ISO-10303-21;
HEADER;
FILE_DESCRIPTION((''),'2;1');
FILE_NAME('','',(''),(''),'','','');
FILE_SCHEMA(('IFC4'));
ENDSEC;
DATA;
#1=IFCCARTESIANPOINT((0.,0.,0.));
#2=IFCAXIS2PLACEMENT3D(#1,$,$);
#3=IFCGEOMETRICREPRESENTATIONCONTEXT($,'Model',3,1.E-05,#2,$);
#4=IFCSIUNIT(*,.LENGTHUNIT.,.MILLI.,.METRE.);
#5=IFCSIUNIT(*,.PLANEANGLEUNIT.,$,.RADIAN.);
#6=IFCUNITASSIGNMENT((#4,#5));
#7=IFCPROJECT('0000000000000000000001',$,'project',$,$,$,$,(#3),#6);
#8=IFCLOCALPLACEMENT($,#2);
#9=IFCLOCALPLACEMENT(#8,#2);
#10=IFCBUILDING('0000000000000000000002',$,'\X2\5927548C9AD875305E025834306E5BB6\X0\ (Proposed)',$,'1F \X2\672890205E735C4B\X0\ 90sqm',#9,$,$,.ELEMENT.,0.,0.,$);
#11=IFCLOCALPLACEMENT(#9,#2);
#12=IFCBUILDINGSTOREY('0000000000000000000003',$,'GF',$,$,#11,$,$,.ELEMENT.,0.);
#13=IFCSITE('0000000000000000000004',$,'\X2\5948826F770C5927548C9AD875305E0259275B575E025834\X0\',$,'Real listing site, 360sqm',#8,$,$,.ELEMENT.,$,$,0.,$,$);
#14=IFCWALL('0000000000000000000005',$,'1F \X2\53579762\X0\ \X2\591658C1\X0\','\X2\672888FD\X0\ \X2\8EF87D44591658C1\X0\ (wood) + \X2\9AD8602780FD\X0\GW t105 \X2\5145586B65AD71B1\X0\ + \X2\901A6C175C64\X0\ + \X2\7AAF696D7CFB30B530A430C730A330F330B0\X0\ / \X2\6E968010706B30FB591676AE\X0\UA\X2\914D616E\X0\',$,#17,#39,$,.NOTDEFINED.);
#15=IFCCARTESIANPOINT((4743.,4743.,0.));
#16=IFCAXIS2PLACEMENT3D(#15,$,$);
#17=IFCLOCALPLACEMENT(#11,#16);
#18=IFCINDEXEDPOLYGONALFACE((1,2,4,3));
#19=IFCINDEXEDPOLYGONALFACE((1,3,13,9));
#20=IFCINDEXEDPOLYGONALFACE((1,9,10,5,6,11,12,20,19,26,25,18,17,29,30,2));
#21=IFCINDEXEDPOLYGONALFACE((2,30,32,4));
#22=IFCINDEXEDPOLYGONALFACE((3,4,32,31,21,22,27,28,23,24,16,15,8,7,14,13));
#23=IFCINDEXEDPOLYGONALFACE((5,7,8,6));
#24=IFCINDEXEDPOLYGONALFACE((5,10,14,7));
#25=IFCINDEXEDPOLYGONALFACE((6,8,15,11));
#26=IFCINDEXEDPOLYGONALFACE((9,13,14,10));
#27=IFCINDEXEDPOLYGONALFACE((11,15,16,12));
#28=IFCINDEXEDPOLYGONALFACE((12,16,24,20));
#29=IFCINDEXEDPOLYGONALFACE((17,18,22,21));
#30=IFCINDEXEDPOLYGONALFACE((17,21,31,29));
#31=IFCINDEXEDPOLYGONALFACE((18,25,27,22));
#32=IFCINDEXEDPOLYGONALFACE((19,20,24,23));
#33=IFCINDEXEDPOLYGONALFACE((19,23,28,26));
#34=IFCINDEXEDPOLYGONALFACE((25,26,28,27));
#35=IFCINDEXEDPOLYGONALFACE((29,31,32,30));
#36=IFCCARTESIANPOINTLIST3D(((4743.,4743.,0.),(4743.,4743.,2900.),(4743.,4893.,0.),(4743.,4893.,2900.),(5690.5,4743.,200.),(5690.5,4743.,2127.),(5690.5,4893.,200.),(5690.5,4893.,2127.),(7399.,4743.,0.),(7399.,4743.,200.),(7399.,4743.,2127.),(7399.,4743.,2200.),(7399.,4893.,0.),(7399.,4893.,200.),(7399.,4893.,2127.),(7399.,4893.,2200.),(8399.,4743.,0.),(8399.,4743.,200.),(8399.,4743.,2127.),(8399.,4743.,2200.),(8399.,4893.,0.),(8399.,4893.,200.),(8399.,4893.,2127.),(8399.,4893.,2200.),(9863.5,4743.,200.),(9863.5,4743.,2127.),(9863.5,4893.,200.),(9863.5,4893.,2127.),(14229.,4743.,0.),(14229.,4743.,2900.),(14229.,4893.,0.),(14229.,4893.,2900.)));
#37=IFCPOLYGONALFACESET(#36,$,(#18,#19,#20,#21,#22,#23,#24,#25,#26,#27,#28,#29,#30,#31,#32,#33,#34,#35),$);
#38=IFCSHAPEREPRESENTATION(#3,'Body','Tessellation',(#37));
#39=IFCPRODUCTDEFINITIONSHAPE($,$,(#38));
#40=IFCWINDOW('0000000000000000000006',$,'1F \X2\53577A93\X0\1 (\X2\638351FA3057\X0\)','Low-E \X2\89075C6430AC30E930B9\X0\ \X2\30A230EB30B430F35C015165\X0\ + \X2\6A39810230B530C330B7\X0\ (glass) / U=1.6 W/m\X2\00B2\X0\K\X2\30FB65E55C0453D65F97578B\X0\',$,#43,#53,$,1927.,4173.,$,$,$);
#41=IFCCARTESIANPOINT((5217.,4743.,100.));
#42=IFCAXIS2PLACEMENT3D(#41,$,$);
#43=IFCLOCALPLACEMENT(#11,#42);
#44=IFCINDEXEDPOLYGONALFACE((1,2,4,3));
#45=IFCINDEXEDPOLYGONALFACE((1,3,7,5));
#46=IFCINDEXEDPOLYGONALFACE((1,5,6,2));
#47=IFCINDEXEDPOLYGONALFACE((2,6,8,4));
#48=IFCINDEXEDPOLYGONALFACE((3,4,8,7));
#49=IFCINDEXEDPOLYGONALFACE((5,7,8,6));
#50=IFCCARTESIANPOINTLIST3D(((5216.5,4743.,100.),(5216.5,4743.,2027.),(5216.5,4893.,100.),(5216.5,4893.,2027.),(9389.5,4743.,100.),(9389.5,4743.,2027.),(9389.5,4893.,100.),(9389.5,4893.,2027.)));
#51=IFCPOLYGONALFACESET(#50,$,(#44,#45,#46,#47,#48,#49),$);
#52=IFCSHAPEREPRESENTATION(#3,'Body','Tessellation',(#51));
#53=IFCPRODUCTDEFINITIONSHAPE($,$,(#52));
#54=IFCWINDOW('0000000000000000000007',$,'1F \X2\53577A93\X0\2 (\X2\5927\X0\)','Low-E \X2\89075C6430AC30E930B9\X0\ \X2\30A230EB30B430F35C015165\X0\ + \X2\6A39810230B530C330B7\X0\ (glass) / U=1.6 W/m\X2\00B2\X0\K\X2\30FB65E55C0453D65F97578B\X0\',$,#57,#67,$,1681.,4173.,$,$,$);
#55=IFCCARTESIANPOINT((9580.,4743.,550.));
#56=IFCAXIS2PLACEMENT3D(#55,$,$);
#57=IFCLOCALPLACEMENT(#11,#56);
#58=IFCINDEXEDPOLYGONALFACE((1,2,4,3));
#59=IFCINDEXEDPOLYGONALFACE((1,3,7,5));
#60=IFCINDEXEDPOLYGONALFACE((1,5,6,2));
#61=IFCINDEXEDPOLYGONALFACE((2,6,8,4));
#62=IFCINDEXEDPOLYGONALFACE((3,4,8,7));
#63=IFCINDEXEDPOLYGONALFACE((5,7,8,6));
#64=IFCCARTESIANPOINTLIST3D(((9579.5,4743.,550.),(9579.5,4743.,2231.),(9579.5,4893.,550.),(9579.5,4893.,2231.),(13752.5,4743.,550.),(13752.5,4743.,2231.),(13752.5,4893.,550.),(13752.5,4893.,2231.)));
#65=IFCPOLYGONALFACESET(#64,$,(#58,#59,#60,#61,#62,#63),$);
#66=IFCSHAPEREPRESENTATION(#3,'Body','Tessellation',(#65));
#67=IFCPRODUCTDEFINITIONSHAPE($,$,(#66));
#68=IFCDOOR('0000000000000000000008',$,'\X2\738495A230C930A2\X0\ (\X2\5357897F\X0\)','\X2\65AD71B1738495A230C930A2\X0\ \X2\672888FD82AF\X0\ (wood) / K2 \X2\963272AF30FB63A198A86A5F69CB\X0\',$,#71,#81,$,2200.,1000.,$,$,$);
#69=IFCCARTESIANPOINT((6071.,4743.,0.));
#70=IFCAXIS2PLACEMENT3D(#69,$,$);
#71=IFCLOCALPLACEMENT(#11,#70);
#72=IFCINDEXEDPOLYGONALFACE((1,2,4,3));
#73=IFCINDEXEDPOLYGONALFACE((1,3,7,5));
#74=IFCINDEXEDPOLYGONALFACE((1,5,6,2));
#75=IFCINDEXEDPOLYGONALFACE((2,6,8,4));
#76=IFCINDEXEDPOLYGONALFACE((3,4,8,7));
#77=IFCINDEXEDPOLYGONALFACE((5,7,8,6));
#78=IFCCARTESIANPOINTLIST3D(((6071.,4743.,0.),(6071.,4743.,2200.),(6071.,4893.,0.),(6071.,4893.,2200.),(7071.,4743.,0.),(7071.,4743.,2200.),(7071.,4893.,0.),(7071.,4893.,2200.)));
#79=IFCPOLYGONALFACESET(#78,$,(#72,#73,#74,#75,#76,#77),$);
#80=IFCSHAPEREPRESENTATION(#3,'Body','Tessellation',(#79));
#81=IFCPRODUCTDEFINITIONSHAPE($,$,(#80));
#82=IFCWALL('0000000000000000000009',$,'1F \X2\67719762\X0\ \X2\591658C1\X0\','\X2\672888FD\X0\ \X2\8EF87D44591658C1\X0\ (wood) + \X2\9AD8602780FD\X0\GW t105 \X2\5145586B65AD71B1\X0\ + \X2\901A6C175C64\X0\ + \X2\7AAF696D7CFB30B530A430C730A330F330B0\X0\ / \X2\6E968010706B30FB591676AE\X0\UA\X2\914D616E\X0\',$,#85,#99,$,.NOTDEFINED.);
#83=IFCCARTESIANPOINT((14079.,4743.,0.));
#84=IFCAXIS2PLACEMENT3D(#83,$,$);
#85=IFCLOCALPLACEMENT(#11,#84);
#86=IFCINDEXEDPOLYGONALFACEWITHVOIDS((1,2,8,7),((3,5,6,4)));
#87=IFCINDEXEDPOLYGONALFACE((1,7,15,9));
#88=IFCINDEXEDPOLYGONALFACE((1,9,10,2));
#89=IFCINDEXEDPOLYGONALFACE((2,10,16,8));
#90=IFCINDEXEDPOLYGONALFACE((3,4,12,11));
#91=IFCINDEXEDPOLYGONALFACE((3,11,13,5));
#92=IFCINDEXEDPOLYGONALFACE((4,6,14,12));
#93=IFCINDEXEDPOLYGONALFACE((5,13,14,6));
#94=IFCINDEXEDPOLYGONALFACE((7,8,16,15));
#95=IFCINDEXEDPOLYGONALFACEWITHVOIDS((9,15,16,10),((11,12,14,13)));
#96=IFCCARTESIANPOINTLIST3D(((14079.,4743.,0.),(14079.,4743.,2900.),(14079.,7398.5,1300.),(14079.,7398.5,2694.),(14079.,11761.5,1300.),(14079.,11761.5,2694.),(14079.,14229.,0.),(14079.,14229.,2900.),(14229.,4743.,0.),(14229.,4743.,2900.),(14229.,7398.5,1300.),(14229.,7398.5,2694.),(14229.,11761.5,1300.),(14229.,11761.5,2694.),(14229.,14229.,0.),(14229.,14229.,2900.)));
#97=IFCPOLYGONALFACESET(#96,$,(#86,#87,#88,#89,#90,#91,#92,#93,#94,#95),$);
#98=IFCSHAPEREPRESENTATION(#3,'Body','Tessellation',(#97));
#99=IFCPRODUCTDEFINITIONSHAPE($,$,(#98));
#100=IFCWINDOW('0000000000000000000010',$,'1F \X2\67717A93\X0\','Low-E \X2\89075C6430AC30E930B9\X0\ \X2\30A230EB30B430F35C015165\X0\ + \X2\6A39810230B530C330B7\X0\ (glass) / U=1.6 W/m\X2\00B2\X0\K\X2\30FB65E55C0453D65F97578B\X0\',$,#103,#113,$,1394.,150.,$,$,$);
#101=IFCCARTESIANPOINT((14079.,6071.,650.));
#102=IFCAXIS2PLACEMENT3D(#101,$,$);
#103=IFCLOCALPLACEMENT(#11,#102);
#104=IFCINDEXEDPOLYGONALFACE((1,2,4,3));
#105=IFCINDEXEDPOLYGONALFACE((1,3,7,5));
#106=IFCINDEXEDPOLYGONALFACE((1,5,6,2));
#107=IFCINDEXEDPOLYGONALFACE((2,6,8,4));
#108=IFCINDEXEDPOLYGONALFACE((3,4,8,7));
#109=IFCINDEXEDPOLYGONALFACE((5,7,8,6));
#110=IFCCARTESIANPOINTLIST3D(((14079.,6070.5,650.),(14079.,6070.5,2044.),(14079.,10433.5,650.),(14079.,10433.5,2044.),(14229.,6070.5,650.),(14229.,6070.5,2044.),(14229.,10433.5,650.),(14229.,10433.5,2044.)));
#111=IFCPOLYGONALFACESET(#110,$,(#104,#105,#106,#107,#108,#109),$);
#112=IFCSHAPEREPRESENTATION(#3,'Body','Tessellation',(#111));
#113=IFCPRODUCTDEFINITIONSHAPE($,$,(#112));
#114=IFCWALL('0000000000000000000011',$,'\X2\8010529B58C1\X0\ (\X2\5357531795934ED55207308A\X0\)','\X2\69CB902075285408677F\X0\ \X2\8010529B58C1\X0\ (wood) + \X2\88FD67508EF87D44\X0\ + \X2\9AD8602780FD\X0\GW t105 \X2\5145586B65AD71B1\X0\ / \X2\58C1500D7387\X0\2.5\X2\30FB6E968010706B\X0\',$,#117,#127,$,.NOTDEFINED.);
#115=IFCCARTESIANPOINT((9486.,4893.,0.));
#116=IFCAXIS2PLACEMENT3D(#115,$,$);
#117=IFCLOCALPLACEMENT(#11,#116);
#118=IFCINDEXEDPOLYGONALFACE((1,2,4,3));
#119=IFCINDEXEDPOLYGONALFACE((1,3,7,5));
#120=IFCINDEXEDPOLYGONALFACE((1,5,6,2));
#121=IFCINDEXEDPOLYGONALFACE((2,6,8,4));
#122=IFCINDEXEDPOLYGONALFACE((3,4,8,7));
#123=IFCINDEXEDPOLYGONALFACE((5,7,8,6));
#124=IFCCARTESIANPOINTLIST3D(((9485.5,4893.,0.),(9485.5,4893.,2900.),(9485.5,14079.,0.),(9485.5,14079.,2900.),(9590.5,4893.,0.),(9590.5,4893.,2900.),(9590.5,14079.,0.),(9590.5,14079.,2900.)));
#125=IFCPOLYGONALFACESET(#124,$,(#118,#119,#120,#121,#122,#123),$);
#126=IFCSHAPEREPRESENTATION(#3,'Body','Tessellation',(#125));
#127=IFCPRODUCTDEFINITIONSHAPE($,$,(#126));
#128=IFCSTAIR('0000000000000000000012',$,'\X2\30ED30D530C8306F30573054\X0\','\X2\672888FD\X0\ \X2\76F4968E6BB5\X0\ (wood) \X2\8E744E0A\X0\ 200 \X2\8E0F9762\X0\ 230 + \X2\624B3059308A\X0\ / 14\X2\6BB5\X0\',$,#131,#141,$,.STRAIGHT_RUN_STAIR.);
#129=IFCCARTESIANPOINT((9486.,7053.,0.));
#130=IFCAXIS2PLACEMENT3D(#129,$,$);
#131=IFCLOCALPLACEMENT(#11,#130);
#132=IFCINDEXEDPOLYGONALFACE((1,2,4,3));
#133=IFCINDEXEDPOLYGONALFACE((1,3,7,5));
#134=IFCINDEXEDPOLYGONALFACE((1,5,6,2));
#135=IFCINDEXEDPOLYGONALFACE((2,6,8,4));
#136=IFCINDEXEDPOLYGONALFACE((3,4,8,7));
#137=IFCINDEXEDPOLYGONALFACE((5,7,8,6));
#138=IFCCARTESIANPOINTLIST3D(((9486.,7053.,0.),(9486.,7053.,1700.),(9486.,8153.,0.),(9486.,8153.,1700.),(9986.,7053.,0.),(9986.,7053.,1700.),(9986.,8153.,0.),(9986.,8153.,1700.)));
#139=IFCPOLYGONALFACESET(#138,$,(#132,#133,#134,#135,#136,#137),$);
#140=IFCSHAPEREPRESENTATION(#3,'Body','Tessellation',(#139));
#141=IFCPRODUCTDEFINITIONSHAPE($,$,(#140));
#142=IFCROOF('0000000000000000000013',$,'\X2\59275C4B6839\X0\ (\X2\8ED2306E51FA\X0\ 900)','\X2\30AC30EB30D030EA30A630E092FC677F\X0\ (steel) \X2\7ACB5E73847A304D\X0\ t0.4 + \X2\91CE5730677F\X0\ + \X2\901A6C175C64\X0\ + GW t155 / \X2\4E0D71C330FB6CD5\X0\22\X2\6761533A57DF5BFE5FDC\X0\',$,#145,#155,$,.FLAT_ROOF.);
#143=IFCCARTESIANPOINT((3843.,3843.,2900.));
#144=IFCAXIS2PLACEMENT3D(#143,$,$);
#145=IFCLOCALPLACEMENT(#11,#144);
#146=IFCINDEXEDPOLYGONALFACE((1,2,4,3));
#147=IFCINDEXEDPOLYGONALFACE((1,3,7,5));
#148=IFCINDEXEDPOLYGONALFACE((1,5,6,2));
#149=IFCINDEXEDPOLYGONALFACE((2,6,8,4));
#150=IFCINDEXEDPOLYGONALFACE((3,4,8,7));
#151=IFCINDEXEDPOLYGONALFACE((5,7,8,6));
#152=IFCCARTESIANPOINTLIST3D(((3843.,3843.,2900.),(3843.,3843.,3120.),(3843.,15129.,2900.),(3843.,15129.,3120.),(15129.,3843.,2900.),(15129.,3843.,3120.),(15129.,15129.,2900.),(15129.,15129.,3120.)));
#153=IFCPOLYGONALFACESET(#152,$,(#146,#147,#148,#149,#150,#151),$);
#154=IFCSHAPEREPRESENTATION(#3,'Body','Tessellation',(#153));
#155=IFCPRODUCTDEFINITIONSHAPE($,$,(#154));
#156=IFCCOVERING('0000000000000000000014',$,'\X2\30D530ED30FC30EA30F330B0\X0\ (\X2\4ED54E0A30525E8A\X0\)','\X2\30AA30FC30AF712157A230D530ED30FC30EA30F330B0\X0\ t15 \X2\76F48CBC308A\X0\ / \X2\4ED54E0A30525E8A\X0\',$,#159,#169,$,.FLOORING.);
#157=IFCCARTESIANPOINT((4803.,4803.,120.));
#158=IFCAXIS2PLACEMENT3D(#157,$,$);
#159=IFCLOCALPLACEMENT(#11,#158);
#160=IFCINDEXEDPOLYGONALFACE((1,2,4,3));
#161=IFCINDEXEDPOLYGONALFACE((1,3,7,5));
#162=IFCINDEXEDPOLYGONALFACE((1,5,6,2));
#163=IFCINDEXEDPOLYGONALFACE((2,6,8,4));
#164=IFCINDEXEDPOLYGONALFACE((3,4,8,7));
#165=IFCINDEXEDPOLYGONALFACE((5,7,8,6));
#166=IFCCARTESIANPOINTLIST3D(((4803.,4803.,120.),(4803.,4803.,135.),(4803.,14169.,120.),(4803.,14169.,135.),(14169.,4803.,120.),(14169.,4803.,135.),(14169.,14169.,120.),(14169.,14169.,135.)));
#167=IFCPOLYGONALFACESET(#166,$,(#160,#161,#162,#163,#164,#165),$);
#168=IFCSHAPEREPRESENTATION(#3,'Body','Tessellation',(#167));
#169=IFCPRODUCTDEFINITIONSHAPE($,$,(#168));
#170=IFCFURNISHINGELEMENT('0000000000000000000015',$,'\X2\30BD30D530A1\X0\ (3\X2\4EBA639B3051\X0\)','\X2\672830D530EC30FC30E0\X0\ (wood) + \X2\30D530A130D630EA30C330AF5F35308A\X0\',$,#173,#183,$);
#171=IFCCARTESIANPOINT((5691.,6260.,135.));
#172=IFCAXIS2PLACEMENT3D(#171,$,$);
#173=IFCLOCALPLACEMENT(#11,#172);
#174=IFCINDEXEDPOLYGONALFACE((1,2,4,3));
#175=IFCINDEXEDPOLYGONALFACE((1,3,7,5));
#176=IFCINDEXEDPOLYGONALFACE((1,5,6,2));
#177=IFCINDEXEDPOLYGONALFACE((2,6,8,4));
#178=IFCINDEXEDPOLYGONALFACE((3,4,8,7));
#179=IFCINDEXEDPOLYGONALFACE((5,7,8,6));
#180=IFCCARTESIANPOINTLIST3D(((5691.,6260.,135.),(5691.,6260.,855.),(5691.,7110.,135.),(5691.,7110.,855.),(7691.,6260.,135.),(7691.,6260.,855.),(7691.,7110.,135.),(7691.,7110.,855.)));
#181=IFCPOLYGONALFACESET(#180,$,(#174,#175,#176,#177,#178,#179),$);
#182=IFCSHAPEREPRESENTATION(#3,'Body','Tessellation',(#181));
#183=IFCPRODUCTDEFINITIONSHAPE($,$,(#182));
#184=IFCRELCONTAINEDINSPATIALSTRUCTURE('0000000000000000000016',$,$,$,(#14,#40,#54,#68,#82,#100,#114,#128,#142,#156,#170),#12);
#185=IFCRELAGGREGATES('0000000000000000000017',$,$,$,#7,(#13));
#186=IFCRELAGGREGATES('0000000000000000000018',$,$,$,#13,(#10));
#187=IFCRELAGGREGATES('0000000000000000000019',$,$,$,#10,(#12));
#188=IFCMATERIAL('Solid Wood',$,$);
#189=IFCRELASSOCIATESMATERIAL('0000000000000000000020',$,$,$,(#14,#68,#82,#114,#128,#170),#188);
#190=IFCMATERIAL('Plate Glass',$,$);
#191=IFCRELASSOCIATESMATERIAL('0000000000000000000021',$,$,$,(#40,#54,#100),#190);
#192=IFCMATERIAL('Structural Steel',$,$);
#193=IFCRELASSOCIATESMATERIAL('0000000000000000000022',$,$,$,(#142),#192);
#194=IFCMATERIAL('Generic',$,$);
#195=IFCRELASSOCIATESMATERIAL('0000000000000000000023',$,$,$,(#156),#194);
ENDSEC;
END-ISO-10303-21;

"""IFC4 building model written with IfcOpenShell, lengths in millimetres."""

from ifc_helpers import new_model, si_unit, frame, frame_2d, origin, place, context, project, spatial, rectangle, extrude, material, element, fill, save


model = new_model("IFC4")

# Units and contexts
model_context = context("Model", 3, precision=1e-05, world=origin())
ifc_project = project(units=[si_unit("LENGTHUNIT", "METRE", prefix="MILLI"), si_unit("PLANEANGLEUNIT", "RADIAN")], contexts=[model_context])

# Site, building, storey
site_placement = place(None, origin())
site = spatial("IfcSite", under=ifc_project, at=site_placement, Name="奈良県大和高田市大字市場", ObjectType="Real listing site, 360sqm", CompositionType="ELEMENT", RefElevation=0.0)
building_placement = place(site_placement, origin())
building = spatial("IfcBuilding", under=site, at=building_placement, Name="大和高田市場の家 (Proposed)", ObjectType="1F 木造平屋 90sqm", CompositionType="ELEMENT", ElevationOfRefHeight=0.0, ElevationOfTerrain=0.0)
storey_placement = place(building_placement, origin())
storey = spatial("IfcBuildingStorey", under=building, at=storey_placement, Name="GF", CompositionType="ELEMENT", Elevation=0.0)

# Shared definitions
ifc_material_1 = material(Name="Solid Wood")

# Wall, openings, windows, door
wall_1_placement = place(storey_placement, frame((4743.0, 4743.0, 0.0)))
wall_1 = element("IfcWall", 1, at=wall_1_placement, inside=storey, material=ifc_material_1, Name="1F 南面 外壁", Description="木製 軸組外壁 (wood) + 高性能GW t105 充填断熱 + 通気層 + 窯業系サイディング / 準耐火・外皮UA配慮", PredefinedType="NOTDEFINED", context=model_context, shape_type="SweptSolid", body=[
    extrude(rectangle(XDim=9486.0, YDim=150.0, at=frame_2d((4743.0, 75.0))), frame((4743.0, 4743.0, 0.0)), (0.0, 0.0, 1.0), 2900.0),
])
opening_1_placement = place(storey_placement, frame((5217.0, 4743.0, 100.0)))
opening_1 = element("IfcOpeningElement", 2, at=opening_1_placement, cuts=wall_1, PredefinedType="NOTDEFINED", context=model_context, shape_type="SweptSolid", body=[
    extrude(rectangle(XDim=4173.0, YDim=150.0, at=frame_2d((2086.0, 75.0))), frame((5217.0, 4743.0, 100.0)), (0.0, 0.0, 1.0), 1927.0),
])
opening_2_placement = place(storey_placement, frame((9580.0, 4743.0, 550.0)))
opening_2 = element("IfcOpeningElement", 3, at=opening_2_placement, cuts=wall_1, PredefinedType="NOTDEFINED", context=model_context, shape_type="SweptSolid", body=[
    extrude(rectangle(XDim=4173.0, YDim=150.0, at=frame_2d((2086.0, 75.0))), frame((9580.0, 4743.0, 550.0)), (0.0, 0.0, 1.0), 1681.0),
])
opening_3_placement = place(storey_placement, frame((6071.0, 4743.0, 0.0)))
opening_3 = element("IfcOpeningElement", 4, at=opening_3_placement, cuts=wall_1, PredefinedType="NOTDEFINED", context=model_context, shape_type="SweptSolid", body=[
    extrude(rectangle(XDim=1000.0, YDim=150.0, at=frame_2d((500.0, 75.0))), frame((6071.0, 4743.0, 0.0)), (0.0, 0.0, 1.0), 2200.0),
])
ifc_material_2 = material(Name="Plate Glass")
window_1_placement = place(storey_placement, frame((5217.0, 4743.0, 100.0)))
window_1 = element("IfcWindow", 5, at=window_1_placement, inside=storey, material=ifc_material_2, Name="1F 南窓1 (掃出し)", Description="Low-E 複層ガラス アルゴン封入 + 樹脂サッシ (glass) / U=1.6 W/m²K・日射取得型", OverallHeight=1927.0, OverallWidth=4173.0, context=model_context, shape_type="SweptSolid", body=[
    extrude(rectangle(XDim=4173.0, YDim=150.0, at=frame_2d((2086.0, 75.0))), frame((5217.0, 4743.0, 100.0)), (0.0, 0.0, 1.0), 1927.0),
])
fill(opening_1, window_1)
window_2_placement = place(storey_placement, frame((9580.0, 4743.0, 550.0)))
window_2 = element("IfcWindow", 6, at=window_2_placement, inside=storey, material=ifc_material_2, Name="1F 南窓2 (大)", Description="Low-E 複層ガラス アルゴン封入 + 樹脂サッシ (glass) / U=1.6 W/m²K・日射取得型", OverallHeight=1681.0, OverallWidth=4173.0, context=model_context, shape_type="SweptSolid", body=[
    extrude(rectangle(XDim=4173.0, YDim=150.0, at=frame_2d((2086.0, 75.0))), frame((9580.0, 4743.0, 550.0)), (0.0, 0.0, 1.0), 1681.0),
])
fill(opening_2, window_2)
door_placement = place(storey_placement, frame((6071.0, 4743.0, 0.0)))
door = element("IfcDoor", 7, at=door_placement, inside=storey, material=ifc_material_1, Name="玄関ドア (南西)", Description="断熱玄関ドア 木製芯 (wood) / K2 防犯・採風機構", OverallHeight=2200.0, OverallWidth=1000.0, context=model_context, shape_type="SweptSolid", body=[
    extrude(rectangle(XDim=1000.0, YDim=150.0, at=frame_2d((500.0, 75.0))), frame((6071.0, 4743.0, 0.0)), (0.0, 0.0, 1.0), 2200.0),
])
fill(opening_3, door)

# Wall, opening, window
wall_2_placement = place(storey_placement, frame((14079.0, 4743.0, 0.0)))
wall_2 = element("IfcWall", 8, at=wall_2_placement, inside=storey, material=ifc_material_1, Name="1F 東面 外壁", Description="木製 軸組外壁 (wood) + 高性能GW t105 充填断熱 + 通気層 + 窯業系サイディング / 準耐火・外皮UA配慮", PredefinedType="NOTDEFINED", context=model_context, shape_type="SweptSolid", body=[
    extrude(rectangle(XDim=150.0, YDim=9486.0, at=frame_2d((75.0, 4743.0))), frame((14079.0, 4743.0, 0.0)), (0.0, 0.0, 1.0), 2900.0),
])
opening_4_placement = place(storey_placement, frame((14079.0, 6071.0, 650.0)))
opening_4 = element("IfcOpeningElement", 9, at=opening_4_placement, cuts=wall_2, PredefinedType="NOTDEFINED", context=model_context, shape_type="SweptSolid", body=[
    extrude(rectangle(XDim=150.0, YDim=4363.0, at=frame_2d((75.0, 2181.0))), frame((14079.0, 6071.0, 650.0)), (0.0, 0.0, 1.0), 1394.0),
])
window_3_placement = place(storey_placement, frame((14079.0, 6071.0, 650.0)))
window_3 = element("IfcWindow", 10, at=window_3_placement, inside=storey, material=ifc_material_2, Name="1F 東窓", Description="Low-E 複層ガラス アルゴン封入 + 樹脂サッシ (glass) / U=1.6 W/m²K・日射取得型", OverallHeight=1394.0, OverallWidth=150.0, context=model_context, shape_type="SweptSolid", body=[
    extrude(rectangle(XDim=150.0, YDim=4363.0, at=frame_2d((75.0, 2181.0))), frame((14079.0, 6071.0, 650.0)), (0.0, 0.0, 1.0), 1394.0),
])
fill(opening_4, window_3)

# Wall
wall_3_placement = place(storey_placement, frame((9486.0, 4893.0, 0.0)))
element("IfcWall", 11, at=wall_3_placement, inside=storey, material=ifc_material_1, Name="耐力壁 (南北間仕切り)", Description="構造用合板 耐力壁 (wood) + 製材軸組 + 高性能GW t105 充填断熱 / 壁倍率2.5・準耐火", PredefinedType="NOTDEFINED", context=model_context, shape_type="SweptSolid", body=[
    extrude(rectangle(XDim=105.0, YDim=9186.0, at=frame_2d((52.0, 4593.0))), frame((9486.0, 4893.0, 0.0)), (0.0, 0.0, 1.0), 2900.0),
])

# Stair
stair_placement = place(storey_placement, frame((9486.0, 7053.0, 0.0)))
element("IfcStair", 12, at=stair_placement, inside=storey, material=ifc_material_1, Name="ロフトはしご", Description="木製 直階段 (wood) 蹴上 200 踏面 230 + 手すり / 14段", PredefinedType="STRAIGHT_RUN_STAIR", context=model_context, shape_type="SweptSolid", body=[
    extrude(rectangle(XDim=500.0, YDim=1100.0, at=frame_2d((250.0, 550.0))), frame((9486.0, 7053.0, 0.0)), (0.0, 0.0, 1.0), 1700.0),
])

# Roof
ifc_material_3 = material(Name="Structural Steel")
roof_placement = place(storey_placement, frame((3843.0, 3843.0, 2900.0)))
element("IfcRoof", 13, at=roof_placement, inside=storey, material=ifc_material_3, Name="大屋根 (軒の出 900)", Description="ガルバリウム鋼板 (steel) 立平葺き t0.4 + 野地板 + 通気層 + GW t155 / 不燃・法22条区域対応", PredefinedType="FLAT_ROOF", context=model_context, shape_type="SweptSolid", body=[
    extrude(rectangle(XDim=11286.0, YDim=11286.0, at=frame_2d((5643.0, 5643.0))), frame((3843.0, 3843.0, 2900.0)), (0.0, 0.0, 1.0), 220.0),
])

# Covering
ifc_material_4 = material(Name="Generic")
covering_placement = place(storey_placement, frame((4803.0, 4803.0, 120.0)))
element("IfcCovering", 14, at=covering_placement, inside=storey, material=ifc_material_4, Name="フローリング (仕上げ床)", Description="オーク無垢フローリング t15 直貼り / 仕上げ床", PredefinedType="FLOORING", context=model_context, shape_type="SweptSolid", body=[
    extrude(rectangle(XDim=9366.0, YDim=9366.0, at=frame_2d((4683.0, 4683.0))), frame((4803.0, 4803.0, 120.0)), (0.0, 0.0, 1.0), 15.0),
])

# Furnishing element
furnishing_1_placement = place(storey_placement, frame((5691.0, 6260.0, 135.0)))
element("IfcFurnishingElement", 15, at=furnishing_1_placement, inside=storey, material=ifc_material_1, Name="ソファ (3人掛け)", Description="木フレーム (wood) + ファブリック張り", context=model_context, shape_type="SweptSolid", body=[
    extrude(rectangle(XDim=2000.0, YDim=850.0, at=frame_2d((1000.0, 425.0))), frame((5691.0, 6260.0, 135.0)), (0.0, 0.0, 1.0), 720.0),
])

save(model, "model.ifc")
